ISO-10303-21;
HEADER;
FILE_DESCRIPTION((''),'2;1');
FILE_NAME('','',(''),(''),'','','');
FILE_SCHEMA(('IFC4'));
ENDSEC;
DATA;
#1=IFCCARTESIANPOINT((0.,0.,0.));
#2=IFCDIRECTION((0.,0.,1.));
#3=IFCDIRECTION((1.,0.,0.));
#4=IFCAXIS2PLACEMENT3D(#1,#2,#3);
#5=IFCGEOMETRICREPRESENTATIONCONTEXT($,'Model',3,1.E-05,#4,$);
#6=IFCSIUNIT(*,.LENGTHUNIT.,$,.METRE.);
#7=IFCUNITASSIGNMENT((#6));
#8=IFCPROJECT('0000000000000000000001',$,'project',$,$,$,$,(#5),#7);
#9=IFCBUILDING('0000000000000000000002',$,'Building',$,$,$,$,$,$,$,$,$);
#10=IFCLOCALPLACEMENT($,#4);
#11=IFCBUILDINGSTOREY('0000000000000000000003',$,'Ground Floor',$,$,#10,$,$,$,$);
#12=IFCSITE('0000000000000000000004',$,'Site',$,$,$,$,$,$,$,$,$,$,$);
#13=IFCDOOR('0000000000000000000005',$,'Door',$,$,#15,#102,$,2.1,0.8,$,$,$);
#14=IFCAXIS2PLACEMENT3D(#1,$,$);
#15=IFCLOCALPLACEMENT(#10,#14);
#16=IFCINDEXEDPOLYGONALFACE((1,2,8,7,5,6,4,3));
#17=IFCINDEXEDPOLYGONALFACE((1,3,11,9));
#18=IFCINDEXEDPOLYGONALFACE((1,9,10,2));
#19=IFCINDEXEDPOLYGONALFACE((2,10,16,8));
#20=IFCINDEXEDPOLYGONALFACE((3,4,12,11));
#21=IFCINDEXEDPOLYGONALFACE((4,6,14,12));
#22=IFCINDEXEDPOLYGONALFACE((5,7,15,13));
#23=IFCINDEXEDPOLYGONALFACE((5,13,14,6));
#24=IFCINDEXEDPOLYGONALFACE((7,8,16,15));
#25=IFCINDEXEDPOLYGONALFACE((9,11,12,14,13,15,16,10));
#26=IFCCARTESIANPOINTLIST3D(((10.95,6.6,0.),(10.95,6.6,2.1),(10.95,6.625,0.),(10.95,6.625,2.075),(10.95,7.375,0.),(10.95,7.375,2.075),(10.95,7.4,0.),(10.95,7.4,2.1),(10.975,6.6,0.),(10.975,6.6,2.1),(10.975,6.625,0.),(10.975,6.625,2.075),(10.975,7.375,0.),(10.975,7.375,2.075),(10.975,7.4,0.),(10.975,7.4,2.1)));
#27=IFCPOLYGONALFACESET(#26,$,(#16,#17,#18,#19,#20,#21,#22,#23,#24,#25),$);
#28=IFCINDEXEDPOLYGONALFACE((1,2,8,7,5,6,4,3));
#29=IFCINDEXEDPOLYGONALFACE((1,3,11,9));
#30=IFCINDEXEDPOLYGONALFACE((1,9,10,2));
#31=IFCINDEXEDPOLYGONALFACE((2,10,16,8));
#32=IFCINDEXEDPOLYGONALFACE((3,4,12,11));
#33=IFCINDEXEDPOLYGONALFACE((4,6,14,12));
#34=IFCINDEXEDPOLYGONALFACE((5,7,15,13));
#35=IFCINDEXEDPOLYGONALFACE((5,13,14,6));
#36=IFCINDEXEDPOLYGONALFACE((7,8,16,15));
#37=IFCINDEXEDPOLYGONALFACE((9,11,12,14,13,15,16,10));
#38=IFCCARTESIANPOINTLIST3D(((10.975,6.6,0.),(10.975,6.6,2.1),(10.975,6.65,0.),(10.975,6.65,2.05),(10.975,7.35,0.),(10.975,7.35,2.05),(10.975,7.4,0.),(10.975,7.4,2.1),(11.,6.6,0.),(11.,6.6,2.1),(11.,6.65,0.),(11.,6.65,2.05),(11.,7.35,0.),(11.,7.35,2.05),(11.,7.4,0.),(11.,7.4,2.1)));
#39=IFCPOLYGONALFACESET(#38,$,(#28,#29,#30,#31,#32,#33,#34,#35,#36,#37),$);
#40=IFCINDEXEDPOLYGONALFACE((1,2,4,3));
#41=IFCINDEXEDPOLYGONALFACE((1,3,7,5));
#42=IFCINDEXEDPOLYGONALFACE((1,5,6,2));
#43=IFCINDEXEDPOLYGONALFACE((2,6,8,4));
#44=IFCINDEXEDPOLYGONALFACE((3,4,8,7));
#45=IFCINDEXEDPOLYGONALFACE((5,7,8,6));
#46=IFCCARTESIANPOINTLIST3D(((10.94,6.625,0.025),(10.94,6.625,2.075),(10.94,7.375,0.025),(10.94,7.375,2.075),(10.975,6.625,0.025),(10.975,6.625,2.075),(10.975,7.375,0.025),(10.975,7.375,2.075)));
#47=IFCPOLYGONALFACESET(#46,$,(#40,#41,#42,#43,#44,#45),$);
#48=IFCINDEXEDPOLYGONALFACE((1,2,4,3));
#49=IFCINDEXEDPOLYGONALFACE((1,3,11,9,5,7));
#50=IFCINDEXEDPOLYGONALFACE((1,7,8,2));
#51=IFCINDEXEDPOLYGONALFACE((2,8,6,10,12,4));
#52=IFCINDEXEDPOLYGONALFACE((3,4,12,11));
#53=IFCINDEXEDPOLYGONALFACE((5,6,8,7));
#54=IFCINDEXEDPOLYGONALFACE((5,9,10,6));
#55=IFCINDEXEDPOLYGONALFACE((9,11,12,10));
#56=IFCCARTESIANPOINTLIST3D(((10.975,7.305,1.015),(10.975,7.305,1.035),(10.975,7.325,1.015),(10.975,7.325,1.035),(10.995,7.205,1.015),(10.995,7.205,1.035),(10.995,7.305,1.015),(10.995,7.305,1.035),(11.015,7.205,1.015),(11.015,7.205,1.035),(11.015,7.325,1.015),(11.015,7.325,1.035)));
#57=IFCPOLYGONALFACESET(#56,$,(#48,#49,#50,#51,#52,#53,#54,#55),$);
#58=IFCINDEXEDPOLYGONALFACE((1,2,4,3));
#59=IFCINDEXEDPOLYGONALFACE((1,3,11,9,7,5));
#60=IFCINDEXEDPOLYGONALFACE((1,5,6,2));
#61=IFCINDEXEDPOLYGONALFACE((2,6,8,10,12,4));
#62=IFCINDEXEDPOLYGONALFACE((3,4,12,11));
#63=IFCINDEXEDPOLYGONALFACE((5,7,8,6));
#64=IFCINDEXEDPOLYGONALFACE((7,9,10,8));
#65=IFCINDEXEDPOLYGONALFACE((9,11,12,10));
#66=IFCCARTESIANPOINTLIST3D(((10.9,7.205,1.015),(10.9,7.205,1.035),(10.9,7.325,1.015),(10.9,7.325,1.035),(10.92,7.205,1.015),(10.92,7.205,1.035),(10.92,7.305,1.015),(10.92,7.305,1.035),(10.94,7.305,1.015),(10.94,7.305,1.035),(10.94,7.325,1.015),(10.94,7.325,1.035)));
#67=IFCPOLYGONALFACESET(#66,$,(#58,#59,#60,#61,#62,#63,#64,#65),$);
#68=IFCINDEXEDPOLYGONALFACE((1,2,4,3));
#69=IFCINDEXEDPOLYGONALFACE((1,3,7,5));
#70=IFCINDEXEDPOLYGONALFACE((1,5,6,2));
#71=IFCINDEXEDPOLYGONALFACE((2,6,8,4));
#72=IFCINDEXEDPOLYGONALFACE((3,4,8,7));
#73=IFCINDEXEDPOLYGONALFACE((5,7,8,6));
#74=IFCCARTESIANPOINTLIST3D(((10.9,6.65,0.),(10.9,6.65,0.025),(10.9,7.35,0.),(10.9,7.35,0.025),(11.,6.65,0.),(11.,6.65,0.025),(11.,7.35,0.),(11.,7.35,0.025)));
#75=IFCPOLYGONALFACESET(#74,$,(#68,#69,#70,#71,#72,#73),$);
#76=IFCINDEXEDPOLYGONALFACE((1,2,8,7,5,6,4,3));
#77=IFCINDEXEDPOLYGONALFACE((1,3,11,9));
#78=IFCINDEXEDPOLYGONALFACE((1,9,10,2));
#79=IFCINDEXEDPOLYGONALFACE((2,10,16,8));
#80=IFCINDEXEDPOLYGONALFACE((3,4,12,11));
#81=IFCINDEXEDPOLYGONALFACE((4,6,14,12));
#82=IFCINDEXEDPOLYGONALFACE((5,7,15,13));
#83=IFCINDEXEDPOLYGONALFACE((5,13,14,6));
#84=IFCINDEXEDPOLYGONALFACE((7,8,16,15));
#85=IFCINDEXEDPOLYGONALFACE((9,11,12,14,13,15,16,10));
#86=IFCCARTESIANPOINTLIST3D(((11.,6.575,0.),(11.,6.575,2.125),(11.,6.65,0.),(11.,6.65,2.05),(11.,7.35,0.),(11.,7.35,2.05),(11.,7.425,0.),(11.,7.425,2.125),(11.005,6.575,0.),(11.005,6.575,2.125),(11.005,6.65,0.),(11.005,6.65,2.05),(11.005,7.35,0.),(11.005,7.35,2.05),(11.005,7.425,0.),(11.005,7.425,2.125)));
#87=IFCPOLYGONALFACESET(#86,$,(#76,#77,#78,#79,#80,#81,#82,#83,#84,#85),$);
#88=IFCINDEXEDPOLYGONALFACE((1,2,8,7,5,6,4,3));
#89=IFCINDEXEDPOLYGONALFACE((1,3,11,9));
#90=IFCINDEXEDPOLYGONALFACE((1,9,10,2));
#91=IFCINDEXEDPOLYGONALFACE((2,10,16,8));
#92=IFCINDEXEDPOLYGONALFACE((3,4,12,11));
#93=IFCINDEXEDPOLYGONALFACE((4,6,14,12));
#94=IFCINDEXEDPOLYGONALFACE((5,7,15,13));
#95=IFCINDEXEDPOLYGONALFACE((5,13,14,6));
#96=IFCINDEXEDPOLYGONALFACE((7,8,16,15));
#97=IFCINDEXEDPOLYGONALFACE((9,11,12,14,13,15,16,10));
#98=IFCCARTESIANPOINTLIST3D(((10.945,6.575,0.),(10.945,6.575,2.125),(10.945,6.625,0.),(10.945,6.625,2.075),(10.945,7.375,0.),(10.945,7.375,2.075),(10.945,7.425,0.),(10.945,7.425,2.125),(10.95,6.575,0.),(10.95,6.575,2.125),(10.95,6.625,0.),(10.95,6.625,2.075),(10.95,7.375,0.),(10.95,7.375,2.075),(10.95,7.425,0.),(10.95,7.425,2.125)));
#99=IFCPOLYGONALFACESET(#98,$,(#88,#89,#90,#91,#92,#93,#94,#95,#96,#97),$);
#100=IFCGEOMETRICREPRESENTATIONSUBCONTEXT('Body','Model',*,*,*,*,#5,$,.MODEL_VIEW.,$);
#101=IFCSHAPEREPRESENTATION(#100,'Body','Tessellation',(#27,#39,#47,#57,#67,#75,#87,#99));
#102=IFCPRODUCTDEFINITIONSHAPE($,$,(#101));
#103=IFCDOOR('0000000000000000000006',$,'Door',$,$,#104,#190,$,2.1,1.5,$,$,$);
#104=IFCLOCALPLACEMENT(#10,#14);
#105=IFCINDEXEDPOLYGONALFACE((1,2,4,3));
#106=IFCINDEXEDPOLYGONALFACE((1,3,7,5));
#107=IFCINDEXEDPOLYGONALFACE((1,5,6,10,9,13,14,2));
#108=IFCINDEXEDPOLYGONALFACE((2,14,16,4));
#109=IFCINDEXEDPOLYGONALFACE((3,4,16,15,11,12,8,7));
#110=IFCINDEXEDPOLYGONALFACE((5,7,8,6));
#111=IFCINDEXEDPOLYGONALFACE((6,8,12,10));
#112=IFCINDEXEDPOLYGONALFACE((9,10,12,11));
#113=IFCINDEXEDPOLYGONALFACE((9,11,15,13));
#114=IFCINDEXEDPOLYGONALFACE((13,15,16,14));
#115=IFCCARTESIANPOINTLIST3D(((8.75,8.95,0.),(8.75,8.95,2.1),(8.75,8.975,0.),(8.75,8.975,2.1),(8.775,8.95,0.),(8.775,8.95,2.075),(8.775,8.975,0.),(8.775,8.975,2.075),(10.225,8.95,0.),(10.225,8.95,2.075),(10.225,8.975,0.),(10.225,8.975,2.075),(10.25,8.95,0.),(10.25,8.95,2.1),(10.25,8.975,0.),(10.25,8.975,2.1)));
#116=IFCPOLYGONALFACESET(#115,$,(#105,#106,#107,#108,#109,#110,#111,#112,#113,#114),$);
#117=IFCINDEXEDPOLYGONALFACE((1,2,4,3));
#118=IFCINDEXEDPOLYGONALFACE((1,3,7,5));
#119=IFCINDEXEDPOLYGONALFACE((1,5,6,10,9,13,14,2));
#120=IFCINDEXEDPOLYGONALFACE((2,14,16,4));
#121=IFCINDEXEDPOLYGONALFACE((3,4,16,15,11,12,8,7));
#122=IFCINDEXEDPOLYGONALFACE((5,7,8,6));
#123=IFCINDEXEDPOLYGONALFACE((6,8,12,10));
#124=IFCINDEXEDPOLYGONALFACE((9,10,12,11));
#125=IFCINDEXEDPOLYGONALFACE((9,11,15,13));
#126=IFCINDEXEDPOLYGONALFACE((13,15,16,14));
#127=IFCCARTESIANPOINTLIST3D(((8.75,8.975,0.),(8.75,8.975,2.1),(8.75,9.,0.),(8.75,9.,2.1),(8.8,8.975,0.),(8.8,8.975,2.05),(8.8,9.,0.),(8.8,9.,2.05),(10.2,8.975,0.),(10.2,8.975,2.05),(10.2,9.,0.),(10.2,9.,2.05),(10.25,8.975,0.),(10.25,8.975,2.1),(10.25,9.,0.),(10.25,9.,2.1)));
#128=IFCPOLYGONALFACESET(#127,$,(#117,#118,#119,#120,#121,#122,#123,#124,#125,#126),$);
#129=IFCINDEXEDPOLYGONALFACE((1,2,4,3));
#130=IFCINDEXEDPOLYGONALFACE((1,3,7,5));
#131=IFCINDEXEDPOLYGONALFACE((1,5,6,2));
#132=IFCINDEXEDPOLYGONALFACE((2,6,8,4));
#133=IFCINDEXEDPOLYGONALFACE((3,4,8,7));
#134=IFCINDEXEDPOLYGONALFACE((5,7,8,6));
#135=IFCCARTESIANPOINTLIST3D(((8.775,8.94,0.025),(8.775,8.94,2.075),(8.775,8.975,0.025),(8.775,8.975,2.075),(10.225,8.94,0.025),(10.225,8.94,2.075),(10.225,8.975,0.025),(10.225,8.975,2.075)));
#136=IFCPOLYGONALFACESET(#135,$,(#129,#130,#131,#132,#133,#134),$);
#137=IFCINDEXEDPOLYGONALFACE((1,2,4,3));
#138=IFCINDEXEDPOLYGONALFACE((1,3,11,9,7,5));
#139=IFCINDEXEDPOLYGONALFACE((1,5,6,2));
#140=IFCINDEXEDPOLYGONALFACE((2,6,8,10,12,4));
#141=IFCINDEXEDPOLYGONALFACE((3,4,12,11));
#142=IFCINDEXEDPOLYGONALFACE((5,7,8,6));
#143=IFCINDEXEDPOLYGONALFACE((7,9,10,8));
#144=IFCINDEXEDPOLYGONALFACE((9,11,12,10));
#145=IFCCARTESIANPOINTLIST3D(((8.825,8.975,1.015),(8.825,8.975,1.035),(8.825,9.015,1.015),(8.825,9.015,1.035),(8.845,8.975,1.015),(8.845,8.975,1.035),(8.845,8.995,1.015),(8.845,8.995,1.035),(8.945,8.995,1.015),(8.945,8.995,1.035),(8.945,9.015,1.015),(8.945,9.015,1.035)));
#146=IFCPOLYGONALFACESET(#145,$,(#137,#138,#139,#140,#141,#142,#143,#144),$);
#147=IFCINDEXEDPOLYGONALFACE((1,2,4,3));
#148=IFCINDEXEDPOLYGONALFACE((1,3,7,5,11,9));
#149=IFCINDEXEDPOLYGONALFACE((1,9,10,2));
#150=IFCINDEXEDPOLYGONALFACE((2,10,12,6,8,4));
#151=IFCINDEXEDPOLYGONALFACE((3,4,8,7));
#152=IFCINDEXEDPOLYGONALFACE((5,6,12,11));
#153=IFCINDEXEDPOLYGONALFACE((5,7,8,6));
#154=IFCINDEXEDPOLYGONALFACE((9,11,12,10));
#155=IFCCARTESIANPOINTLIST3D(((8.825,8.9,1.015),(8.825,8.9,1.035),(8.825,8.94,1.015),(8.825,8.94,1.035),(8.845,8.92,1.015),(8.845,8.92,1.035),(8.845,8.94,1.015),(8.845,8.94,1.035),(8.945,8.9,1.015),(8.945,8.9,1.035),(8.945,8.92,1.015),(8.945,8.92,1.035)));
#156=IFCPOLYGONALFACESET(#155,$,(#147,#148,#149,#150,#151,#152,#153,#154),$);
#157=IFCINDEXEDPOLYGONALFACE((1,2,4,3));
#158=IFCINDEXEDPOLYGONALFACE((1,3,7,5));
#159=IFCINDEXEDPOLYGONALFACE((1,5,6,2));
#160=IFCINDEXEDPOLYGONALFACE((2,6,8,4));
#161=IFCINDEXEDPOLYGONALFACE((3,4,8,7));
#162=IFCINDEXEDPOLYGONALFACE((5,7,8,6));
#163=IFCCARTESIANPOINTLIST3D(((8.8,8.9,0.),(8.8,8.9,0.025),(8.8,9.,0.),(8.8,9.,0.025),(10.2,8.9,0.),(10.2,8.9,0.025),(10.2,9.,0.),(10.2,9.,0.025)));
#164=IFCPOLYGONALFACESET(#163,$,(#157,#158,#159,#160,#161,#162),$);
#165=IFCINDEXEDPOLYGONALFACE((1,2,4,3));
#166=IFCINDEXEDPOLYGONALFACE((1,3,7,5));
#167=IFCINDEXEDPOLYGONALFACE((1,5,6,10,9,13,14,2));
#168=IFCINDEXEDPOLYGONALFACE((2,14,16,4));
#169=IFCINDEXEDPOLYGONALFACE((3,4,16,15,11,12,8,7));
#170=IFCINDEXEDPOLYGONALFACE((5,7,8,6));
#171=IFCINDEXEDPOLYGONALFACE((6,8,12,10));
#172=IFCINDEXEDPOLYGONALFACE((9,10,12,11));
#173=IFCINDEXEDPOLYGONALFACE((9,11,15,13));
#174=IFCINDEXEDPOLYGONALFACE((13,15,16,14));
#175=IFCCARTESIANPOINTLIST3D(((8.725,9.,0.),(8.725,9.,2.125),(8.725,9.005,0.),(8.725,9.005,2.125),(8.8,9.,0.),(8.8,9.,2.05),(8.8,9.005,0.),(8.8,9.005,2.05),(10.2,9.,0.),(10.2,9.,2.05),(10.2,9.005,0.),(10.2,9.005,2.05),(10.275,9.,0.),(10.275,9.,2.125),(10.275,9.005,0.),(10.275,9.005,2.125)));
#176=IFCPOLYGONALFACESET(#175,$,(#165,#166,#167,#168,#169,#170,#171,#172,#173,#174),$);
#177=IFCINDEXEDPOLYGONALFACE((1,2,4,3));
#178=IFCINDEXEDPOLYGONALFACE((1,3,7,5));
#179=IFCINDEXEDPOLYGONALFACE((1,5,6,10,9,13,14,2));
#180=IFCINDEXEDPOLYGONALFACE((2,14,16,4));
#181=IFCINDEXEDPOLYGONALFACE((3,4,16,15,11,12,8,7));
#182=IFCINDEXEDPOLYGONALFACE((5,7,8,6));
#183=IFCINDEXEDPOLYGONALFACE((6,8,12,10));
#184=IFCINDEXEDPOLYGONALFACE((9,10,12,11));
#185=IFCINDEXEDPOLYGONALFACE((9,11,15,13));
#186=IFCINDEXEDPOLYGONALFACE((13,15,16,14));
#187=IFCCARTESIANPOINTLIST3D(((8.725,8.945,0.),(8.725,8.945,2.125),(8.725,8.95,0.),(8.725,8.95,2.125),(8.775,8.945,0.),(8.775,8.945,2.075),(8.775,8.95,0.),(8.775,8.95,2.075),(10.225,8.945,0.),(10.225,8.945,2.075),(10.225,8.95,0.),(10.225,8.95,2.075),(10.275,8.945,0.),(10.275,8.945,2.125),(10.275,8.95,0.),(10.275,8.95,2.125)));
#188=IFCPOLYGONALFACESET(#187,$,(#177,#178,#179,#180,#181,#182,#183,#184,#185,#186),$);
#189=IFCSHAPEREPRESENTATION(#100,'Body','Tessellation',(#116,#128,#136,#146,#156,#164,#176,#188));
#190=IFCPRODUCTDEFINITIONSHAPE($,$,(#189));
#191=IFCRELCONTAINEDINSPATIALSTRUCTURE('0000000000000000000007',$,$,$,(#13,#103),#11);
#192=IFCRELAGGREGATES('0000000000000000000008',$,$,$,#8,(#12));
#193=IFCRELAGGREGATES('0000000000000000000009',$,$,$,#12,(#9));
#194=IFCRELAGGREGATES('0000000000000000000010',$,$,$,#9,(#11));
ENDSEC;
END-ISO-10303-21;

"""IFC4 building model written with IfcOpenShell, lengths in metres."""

from ifc_helpers import new_model, si_unit, frame, origin_with_axes, place, context, subcontext, project, spatial, line, indexed_curve, outline, extrude, element, save


model = new_model("IFC4")

# Units and contexts
model_context = context("Model", 3, precision=1e-05, world=origin_with_axes())
body_context = subcontext(model_context, "Body", "Model", "MODEL_VIEW")
ifc_project = project(units=[si_unit("LENGTHUNIT", "METRE")], contexts=[model_context])

# Site, building, storey
site = spatial("IfcSite", under=ifc_project, Name="Site")
building = spatial("IfcBuilding", under=site, Name="Building")
storey_placement = place(None, origin_with_axes())
storey = spatial("IfcBuildingStorey", under=building, at=storey_placement, Name="Ground Floor")

# Doors
door_1_placement = place(storey_placement, frame((11.0, 6.6, 0.0), z_axis=(0.0, 0.0, 1.0), x_axis=(0.0, 1.0, 0.0)))
element("IfcDoor", 1, at=door_1_placement, inside=storey, Name="Door", OverallHeight=2.1, OverallWidth=0.8, context=body_context, shape_type="SweptSolid", body=[
    extrude(outline(indexed_curve([(0.0, 0.0), (0.0, 2.1), (0.8, 2.1), (0.8, 0.0), (0.775, 0.0), (0.775, 2.075), (0.025, 2.075), (0.025, 0.0)], segments=[line(1, 2, 3, 4, 5, 6, 7, 8, 1)])), frame((0.0, 0.025, 0.0), z_axis=(0.0, -1.0, 0.0), x_axis=(1.0, 0.0, 0.0)), (0.0, 0.0, -1.0), 0.025),
    extrude(outline(indexed_curve([(0.0, 0.0), (0.0, 2.1), (0.8, 2.1), (0.8, 0.0), (0.75, 0.0), (0.75, 2.05), (0.05, 2.05), (0.05, 0.0)], segments=[line(1, 2, 3, 4, 5, 6, 7, 8, 1)])), frame((0.0, 0.0, 0.0), z_axis=(0.0, -1.0, 0.0), x_axis=(1.0, 0.0, 0.0)), (0.0, 0.0, -1.0), 0.025),
    extrude(outline(indexed_curve([(0.0, 0.0), (0.75, 0.0), (0.75, 0.035), (0.0, 0.035)], segments=[line(1, 2, 3, 4, 1)])), frame((0.025, 0.025, 0.025), z_axis=(0.0, 0.0, 1.0), x_axis=(1.0, 0.0, 0.0)), (0.0, 0.0, 1.0), 2.05),
    extrude(outline(indexed_curve([(0.0, 0.0), (0.0, -0.04), (-0.12, -0.04), (-0.12, -0.02), (-0.02, -0.02), (-0.02, 0.0)], segments=[line(1, 2, 3, 4, 5, 6, 1)])), frame((0.725, 0.025, 1.015), z_axis=(0.0, 0.0, 1.0), x_axis=(1.0, 0.0, 0.0)), (0.0, 0.0, 1.0), 0.02),
    extrude(outline(indexed_curve([(0.0, 0.0), (0.0, 0.04), (-0.12, 0.04), (-0.12, 0.02), (-0.02, 0.02), (-0.02, 0.0)], segments=[line(1, 2, 3, 4, 5, 6, 1)])), frame((0.725, 0.06, 1.015), z_axis=(0.0, 0.0, 1.0), x_axis=(1.0, 0.0, 0.0)), (0.0, 0.0, 1.0), 0.02),
    extrude(outline(indexed_curve([(0.0, 0.0), (0.7, 0.0), (0.7, 0.1), (0.0, 0.1)], segments=[line(1, 2, 3, 4, 1)])), frame((0.05, 0.0, 0.0), z_axis=(0.0, 0.0, 1.0), x_axis=(1.0, 0.0, 0.0)), (0.0, 0.0, 1.0), 0.025),
    extrude(outline(indexed_curve([(0.0, 0.0), (0.0, 2.125), (0.85, 2.125), (0.85, 0.0), (0.775, 0.0), (0.775, 2.05), (0.075, 2.05), (0.075, 0.0)], segments=[line(1, 2, 3, 4, 5, 6, 7, 8, 1)])), frame((-0.025, -0.005, 0.0), z_axis=(0.0, -1.0, 0.0), x_axis=(1.0, 0.0, 0.0)), (0.0, 0.0, -1.0), 0.005),
    extrude(outline(indexed_curve([(0.0, 0.0), (0.0, 2.125), (0.85, 2.125), (0.85, 0.0), (0.8, 0.0), (0.8, 2.075), (0.05, 2.075), (0.05, 0.0)], segments=[line(1, 2, 3, 4, 5, 6, 7, 8, 1)])), frame((-0.025, 0.05, 0.0), z_axis=(0.0, -1.0, 0.0), x_axis=(1.0, 0.0, 0.0)), (0.0, 0.0, -1.0), 0.005),
])
door_2_placement = place(storey_placement, frame((10.25, 9.0, 0.0), z_axis=(0.0, 0.0, 1.0), x_axis=(-1.0, 0.0, 0.0)))
element("IfcDoor", 2, at=door_2_placement, inside=storey, Name="Door", OverallHeight=2.1, OverallWidth=1.5, context=body_context, shape_type="SweptSolid", body=[
    extrude(outline(indexed_curve([(0.0, 0.0), (0.0, 2.1), (1.5, 2.1), (1.5, 0.0), (1.475, 0.0), (1.475, 2.075), (0.025, 2.075), (0.025, 0.0)], segments=[line(1, 2, 3, 4, 5, 6, 7, 8, 1)])), frame((0.0, 0.025, 0.0), z_axis=(0.0, -1.0, 0.0), x_axis=(1.0, 0.0, 0.0)), (0.0, 0.0, -1.0), 0.025),
    extrude(outline(indexed_curve([(0.0, 0.0), (0.0, 2.1), (1.5, 2.1), (1.5, 0.0), (1.45, 0.0), (1.45, 2.05), (0.05, 2.05), (0.05, 0.0)], segments=[line(1, 2, 3, 4, 5, 6, 7, 8, 1)])), frame((0.0, 0.0, 0.0), z_axis=(0.0, -1.0, 0.0), x_axis=(1.0, 0.0, 0.0)), (0.0, 0.0, -1.0), 0.025),
    extrude(outline(indexed_curve([(0.0, 0.0), (1.45, 0.0), (1.45, 0.035), (0.0, 0.035)], segments=[line(1, 2, 3, 4, 1)])), frame((0.025, 0.025, 0.025), z_axis=(0.0, 0.0, 1.0), x_axis=(1.0, 0.0, 0.0)), (0.0, 0.0, 1.0), 2.05),
    extrude(outline(indexed_curve([(0.0, 0.0), (0.0, -0.04), (-0.12, -0.04), (-0.12, -0.02), (-0.02, -0.02), (-0.02, 0.0)], segments=[line(1, 2, 3, 4, 5, 6, 1)])), frame((1.425, 0.025, 1.015), z_axis=(0.0, 0.0, 1.0), x_axis=(1.0, 0.0, 0.0)), (0.0, 0.0, 1.0), 0.02),
    extrude(outline(indexed_curve([(0.0, 0.0), (0.0, 0.04), (-0.12, 0.04), (-0.12, 0.02), (-0.02, 0.02), (-0.02, 0.0)], segments=[line(1, 2, 3, 4, 5, 6, 1)])), frame((1.425, 0.06, 1.015), z_axis=(0.0, 0.0, 1.0), x_axis=(1.0, 0.0, 0.0)), (0.0, 0.0, 1.0), 0.02),
    extrude(outline(indexed_curve([(0.0, 0.0), (1.4, 0.0), (1.4, 0.1), (0.0, 0.1)], segments=[line(1, 2, 3, 4, 1)])), frame((0.05, 0.0, 0.0), z_axis=(0.0, 0.0, 1.0), x_axis=(1.0, 0.0, 0.0)), (0.0, 0.0, 1.0), 0.025),
    extrude(outline(indexed_curve([(0.0, 0.0), (0.0, 2.125), (1.55, 2.125), (1.55, 0.0), (1.475, 0.0), (1.475, 2.05), (0.075, 2.05), (0.075, 0.0)], segments=[line(1, 2, 3, 4, 5, 6, 7, 8, 1)])), frame((-0.025, -0.005, 0.0), z_axis=(0.0, -1.0, 0.0), x_axis=(1.0, 0.0, 0.0)), (0.0, 0.0, -1.0), 0.005),
    extrude(outline(indexed_curve([(0.0, 0.0), (0.0, 2.125), (1.55, 2.125), (1.55, 0.0), (1.5, 0.0), (1.5, 2.075), (0.05, 2.075), (0.05, 0.0)], segments=[line(1, 2, 3, 4, 5, 6, 7, 8, 1)])), frame((-0.025, 0.05, 0.0), z_axis=(0.0, -1.0, 0.0), x_axis=(1.0, 0.0, 0.0)), (0.0, 0.0, -1.0), 0.005),
])

save(model, "model.ifc")
